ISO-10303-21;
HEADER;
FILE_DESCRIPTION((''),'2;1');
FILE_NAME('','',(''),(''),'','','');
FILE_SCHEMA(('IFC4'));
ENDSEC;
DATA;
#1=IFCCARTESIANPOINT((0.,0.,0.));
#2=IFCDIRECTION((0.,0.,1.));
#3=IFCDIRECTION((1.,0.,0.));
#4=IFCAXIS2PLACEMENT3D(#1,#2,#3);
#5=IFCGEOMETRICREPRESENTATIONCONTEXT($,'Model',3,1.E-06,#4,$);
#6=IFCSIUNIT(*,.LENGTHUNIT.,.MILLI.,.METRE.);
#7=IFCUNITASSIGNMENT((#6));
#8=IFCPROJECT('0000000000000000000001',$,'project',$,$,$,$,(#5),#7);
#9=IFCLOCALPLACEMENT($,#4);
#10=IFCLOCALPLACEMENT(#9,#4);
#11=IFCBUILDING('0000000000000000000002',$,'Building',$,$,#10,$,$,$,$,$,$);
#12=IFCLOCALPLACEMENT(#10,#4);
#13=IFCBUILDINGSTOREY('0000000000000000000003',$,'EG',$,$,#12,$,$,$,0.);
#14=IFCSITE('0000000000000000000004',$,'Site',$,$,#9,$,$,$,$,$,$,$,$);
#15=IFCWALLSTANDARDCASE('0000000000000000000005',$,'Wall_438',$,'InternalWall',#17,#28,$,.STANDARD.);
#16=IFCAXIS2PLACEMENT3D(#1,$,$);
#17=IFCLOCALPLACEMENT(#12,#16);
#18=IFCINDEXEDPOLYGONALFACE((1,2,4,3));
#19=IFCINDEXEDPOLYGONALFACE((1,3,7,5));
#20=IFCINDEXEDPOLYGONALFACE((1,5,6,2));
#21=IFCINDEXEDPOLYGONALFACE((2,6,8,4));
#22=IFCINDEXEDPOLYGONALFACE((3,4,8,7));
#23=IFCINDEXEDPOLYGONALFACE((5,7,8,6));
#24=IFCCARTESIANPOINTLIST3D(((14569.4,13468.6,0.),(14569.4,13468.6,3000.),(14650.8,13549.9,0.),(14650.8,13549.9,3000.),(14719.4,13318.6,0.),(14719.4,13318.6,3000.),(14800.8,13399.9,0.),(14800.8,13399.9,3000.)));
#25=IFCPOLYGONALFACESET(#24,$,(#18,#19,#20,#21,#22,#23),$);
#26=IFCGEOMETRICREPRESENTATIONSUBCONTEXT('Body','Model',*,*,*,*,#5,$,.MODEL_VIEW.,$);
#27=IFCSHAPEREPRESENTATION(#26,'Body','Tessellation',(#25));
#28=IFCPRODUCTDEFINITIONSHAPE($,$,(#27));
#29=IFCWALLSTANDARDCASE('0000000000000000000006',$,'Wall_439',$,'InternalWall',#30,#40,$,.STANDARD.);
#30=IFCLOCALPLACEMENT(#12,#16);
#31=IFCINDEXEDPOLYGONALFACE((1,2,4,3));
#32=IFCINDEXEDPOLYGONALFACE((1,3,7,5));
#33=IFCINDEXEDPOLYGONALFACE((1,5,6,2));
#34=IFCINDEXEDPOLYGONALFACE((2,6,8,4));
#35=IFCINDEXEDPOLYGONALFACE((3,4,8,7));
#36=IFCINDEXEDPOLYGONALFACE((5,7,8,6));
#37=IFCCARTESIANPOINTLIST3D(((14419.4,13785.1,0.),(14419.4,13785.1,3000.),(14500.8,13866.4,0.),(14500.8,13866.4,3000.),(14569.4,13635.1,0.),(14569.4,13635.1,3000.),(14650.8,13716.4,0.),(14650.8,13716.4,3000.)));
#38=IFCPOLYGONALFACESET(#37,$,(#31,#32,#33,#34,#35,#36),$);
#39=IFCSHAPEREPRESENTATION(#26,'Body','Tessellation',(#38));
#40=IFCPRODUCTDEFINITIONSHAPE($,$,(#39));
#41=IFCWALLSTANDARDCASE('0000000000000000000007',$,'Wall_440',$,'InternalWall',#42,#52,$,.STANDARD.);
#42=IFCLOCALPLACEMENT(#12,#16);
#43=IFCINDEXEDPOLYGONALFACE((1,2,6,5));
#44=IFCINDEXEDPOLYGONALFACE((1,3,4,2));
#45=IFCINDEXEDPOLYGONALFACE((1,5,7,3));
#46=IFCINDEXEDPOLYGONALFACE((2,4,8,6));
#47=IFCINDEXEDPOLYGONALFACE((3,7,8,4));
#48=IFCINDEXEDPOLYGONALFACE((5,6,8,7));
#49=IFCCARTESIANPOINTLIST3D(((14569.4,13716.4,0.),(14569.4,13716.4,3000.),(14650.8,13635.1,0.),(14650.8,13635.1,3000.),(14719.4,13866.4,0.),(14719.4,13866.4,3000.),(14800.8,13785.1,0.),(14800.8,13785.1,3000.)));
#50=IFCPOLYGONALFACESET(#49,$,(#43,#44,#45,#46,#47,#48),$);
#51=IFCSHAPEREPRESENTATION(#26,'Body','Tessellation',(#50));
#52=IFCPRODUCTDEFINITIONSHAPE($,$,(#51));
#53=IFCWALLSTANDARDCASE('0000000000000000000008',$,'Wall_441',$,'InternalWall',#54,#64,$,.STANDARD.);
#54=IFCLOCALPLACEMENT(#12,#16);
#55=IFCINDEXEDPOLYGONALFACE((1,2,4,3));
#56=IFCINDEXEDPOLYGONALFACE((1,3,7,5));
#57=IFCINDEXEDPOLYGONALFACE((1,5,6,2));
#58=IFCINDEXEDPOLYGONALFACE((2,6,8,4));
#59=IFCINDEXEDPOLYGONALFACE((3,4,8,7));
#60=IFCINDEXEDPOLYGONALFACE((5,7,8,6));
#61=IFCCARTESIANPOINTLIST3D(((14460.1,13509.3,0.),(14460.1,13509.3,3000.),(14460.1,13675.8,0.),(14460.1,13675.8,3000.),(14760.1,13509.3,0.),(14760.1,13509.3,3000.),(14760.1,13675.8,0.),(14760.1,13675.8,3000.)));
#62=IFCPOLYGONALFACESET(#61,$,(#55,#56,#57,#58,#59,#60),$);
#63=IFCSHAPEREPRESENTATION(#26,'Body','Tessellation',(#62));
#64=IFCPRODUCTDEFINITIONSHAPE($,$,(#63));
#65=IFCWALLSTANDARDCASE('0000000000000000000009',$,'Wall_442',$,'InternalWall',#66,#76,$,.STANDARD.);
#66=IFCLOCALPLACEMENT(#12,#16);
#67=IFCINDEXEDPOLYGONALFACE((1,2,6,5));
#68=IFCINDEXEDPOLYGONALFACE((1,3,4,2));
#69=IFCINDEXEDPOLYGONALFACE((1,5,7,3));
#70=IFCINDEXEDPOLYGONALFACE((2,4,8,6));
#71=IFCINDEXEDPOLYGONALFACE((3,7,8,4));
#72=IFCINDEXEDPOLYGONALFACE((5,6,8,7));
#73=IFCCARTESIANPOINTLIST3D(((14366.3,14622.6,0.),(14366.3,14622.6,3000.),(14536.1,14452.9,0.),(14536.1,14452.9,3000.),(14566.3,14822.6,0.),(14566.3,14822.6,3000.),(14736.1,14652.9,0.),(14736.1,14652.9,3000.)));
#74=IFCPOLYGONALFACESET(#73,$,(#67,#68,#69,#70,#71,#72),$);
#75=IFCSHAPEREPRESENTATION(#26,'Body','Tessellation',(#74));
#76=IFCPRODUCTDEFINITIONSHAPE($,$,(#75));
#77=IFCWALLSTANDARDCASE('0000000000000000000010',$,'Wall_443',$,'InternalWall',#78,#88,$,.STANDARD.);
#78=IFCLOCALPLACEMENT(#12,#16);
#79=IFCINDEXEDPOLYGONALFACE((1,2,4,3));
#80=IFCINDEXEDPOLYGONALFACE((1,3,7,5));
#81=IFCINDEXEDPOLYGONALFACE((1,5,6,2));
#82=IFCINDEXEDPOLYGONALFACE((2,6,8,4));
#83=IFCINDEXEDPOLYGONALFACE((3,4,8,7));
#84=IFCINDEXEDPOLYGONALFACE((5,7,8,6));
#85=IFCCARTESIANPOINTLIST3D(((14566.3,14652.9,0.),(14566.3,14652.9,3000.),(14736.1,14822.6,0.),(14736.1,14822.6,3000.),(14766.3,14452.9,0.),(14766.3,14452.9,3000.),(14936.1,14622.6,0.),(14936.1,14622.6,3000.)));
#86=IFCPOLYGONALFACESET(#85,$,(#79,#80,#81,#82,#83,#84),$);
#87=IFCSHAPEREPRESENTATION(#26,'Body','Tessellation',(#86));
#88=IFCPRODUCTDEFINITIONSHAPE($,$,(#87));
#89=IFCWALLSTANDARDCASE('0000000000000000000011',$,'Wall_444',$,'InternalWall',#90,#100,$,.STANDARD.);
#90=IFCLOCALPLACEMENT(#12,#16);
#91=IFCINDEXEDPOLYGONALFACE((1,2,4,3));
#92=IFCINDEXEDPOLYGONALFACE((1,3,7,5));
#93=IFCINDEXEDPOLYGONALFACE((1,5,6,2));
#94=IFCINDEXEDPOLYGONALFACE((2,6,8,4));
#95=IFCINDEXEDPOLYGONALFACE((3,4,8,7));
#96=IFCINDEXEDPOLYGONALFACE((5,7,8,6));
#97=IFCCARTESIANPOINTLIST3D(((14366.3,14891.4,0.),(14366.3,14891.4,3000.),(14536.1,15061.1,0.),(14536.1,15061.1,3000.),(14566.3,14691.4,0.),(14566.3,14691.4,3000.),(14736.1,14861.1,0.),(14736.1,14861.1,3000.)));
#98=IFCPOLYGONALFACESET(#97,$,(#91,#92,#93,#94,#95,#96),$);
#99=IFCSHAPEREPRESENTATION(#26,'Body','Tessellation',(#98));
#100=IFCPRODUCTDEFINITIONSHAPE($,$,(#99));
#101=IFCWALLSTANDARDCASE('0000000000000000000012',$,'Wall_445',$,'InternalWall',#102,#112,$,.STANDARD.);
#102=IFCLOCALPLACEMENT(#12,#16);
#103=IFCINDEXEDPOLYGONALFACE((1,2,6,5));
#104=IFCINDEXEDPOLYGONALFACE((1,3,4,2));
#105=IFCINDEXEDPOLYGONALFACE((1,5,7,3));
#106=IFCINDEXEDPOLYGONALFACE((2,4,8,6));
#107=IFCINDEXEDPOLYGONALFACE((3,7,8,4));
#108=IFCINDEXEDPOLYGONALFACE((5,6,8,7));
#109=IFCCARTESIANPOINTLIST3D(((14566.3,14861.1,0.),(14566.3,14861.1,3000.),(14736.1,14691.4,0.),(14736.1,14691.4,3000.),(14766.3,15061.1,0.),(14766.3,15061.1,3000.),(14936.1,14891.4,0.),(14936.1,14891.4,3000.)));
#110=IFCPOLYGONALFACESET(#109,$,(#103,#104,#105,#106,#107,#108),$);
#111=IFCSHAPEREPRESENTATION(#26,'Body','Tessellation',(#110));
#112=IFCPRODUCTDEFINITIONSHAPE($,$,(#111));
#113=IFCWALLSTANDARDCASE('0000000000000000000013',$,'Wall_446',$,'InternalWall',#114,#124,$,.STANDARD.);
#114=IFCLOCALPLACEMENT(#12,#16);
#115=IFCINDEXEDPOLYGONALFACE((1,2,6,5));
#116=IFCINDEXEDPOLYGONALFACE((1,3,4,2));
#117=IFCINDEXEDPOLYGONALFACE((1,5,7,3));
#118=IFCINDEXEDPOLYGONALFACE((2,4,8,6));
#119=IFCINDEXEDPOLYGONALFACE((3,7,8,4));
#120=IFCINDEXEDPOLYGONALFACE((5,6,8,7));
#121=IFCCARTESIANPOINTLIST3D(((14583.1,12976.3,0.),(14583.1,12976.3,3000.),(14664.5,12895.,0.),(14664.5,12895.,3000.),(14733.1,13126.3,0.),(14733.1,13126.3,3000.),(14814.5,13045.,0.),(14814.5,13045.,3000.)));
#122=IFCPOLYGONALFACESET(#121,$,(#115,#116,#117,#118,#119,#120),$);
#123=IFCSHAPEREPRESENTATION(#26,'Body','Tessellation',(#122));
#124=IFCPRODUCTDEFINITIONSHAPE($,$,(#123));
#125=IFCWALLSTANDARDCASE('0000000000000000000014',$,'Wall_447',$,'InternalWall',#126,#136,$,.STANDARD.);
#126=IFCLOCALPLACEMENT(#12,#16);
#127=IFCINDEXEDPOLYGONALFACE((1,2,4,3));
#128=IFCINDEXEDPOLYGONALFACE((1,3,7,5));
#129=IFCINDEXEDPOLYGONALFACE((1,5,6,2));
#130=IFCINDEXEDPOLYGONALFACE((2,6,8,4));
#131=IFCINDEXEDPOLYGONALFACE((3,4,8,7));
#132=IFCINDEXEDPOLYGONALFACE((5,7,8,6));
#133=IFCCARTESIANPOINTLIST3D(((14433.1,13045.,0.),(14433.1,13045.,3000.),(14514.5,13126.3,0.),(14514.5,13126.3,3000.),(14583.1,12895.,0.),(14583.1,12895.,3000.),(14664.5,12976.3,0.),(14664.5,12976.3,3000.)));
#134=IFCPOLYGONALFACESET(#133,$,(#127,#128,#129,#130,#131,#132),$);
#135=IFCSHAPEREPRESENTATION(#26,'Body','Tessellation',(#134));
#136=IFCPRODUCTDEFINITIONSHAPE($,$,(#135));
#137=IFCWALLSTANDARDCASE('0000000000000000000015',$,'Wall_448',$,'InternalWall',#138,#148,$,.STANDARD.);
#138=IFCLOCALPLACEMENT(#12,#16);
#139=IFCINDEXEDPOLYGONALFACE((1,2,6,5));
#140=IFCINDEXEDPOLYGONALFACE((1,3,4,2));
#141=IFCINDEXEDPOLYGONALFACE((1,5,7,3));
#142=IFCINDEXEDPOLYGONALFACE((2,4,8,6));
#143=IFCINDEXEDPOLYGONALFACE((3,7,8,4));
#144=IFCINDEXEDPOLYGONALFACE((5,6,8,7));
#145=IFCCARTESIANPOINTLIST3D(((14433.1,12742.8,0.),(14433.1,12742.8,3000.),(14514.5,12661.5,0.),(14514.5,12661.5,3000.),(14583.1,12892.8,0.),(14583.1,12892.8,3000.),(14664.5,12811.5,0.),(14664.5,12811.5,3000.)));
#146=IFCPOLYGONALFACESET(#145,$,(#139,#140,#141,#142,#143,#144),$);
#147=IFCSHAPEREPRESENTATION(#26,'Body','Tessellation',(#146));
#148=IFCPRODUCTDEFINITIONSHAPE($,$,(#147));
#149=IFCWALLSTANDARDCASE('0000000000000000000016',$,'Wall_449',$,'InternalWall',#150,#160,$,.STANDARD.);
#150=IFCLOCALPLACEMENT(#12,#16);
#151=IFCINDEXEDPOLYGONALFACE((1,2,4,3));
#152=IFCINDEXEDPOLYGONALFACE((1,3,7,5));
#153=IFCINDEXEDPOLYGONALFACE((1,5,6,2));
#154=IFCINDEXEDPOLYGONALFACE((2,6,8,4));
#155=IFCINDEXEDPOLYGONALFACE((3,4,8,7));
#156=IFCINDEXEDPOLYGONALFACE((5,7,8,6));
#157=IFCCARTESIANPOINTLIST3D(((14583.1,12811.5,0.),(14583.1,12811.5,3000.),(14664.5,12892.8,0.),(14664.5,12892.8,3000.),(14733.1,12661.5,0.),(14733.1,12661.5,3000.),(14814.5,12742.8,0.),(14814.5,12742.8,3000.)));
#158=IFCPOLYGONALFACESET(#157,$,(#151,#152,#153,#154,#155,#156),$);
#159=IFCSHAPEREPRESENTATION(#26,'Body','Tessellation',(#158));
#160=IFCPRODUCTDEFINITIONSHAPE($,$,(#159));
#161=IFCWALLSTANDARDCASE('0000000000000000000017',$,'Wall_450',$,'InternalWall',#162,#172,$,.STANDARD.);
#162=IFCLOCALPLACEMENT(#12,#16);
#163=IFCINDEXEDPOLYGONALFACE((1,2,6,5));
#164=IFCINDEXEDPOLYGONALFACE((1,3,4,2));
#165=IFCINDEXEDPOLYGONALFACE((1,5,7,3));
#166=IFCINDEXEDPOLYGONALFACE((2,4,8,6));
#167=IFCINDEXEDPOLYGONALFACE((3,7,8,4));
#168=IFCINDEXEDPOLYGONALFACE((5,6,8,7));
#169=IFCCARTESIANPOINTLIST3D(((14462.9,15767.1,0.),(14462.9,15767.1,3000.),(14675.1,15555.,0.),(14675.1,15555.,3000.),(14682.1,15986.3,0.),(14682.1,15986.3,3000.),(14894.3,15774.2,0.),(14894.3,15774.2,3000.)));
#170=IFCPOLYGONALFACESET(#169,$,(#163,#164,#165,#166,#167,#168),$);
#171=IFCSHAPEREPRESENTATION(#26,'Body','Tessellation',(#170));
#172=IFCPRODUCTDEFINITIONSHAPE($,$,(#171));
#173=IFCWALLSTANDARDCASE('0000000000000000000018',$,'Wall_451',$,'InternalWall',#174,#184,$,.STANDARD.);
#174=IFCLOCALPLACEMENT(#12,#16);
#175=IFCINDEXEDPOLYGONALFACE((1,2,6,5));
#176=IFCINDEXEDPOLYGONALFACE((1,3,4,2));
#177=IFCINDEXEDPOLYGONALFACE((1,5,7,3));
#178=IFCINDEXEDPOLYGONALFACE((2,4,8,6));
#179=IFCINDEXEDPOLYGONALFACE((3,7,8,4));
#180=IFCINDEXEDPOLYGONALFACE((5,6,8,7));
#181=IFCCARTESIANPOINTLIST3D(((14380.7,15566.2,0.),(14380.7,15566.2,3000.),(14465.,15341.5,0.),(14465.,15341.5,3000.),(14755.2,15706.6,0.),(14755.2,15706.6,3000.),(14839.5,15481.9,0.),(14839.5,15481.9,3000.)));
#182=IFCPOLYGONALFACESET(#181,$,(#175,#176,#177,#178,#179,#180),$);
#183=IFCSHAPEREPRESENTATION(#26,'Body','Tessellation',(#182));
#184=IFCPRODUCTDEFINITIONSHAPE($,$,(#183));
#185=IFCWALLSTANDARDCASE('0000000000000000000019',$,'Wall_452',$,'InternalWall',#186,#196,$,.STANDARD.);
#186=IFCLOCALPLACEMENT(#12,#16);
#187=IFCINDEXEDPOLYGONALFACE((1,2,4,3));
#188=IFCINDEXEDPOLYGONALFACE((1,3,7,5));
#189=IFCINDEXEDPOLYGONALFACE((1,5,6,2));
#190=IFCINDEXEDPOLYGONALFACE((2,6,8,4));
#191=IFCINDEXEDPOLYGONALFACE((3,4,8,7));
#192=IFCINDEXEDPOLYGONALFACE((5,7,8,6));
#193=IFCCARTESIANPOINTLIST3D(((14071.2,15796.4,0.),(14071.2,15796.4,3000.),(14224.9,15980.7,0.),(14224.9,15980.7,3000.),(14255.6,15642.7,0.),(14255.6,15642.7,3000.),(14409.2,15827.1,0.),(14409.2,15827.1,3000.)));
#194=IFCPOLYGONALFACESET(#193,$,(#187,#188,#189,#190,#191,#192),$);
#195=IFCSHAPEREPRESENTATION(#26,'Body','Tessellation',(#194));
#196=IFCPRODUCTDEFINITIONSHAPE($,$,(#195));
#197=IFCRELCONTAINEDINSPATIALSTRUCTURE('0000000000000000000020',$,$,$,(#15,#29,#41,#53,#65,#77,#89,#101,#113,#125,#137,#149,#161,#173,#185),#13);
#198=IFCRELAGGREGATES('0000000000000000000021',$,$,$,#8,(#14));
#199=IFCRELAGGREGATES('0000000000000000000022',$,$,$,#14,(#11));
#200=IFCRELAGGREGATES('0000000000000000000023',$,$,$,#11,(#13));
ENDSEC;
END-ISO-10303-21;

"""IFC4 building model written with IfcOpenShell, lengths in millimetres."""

from ifc_helpers import new_model, si_unit, frame, origin_with_axes, place, context, subcontext, project, spatial, rectangle, extrude, element, save


model = new_model("IFC4")

# Units and contexts
model_context = context("Model", 3, precision=1e-06, world=origin_with_axes())
body_context = subcontext(model_context, "Body", "Model", "MODEL_VIEW")
ifc_project = project(units=[si_unit("LENGTHUNIT", "METRE", prefix="MILLI")], contexts=[model_context])

# Site, building, storey
site_placement = place(None, origin_with_axes())
site = spatial("IfcSite", under=ifc_project, at=site_placement, Name="Site")
building_placement = place(site_placement, origin_with_axes())
building = spatial("IfcBuilding", under=site, at=building_placement, Name="Building")
storey_placement = place(building_placement, origin_with_axes())
storey = spatial("IfcBuildingStorey", under=building, at=storey_placement, Name="EG", Elevation=0.0)

# Walls
wall_1_placement = place(storey_placement, origin_with_axes())
element("IfcWallStandardCase", 1, at=wall_1_placement, inside=storey, Name="Wall_438", ObjectType="InternalWall", PredefinedType="STANDARD", context=body_context, shape_type="SweptSolid", body=[
    extrude(rectangle(XDim=212.1, YDim=115.0), frame((14685.1, 13434.3, 0.0), z_axis=(0.0, 0.0, 1.0), x_axis=(0.707107, -0.707107, 0.0)), (0.0, 0.0, 1.0), 3000.0),
])
wall_2_placement = place(storey_placement, origin_with_axes())
element("IfcWallStandardCase", 2, at=wall_2_placement, inside=storey, Name="Wall_439", ObjectType="InternalWall", PredefinedType="STANDARD", context=body_context, shape_type="SweptSolid", body=[
    extrude(rectangle(XDim=212.1, YDim=115.0), frame((14535.1, 13750.8, 0.0), z_axis=(0.0, 0.0, 1.0), x_axis=(-0.707107, 0.707107, 0.0)), (0.0, 0.0, 1.0), 3000.0),
])
wall_3_placement = place(storey_placement, origin_with_axes())
element("IfcWallStandardCase", 3, at=wall_3_placement, inside=storey, Name="Wall_440", ObjectType="InternalWall", PredefinedType="STANDARD", context=body_context, shape_type="SweptSolid", body=[
    extrude(rectangle(XDim=212.1, YDim=115.0), frame((14685.1, 13750.8, 0.0), z_axis=(0.0, 0.0, 1.0), x_axis=(0.707107, 0.707107, 0.0)), (0.0, 0.0, 1.0), 3000.0),
])
wall_4_placement = place(storey_placement, origin_with_axes())
element("IfcWallStandardCase", 4, at=wall_4_placement, inside=storey, Name="Wall_441", ObjectType="InternalWall", PredefinedType="STANDARD", context=body_context, shape_type="SweptSolid", body=[
    extrude(rectangle(XDim=166.5, YDim=300.0), frame((14610.1, 13592.5, 0.0), z_axis=(0.0, 0.0, 1.0), x_axis=(0.0, 1.0, 0.0)), (0.0, 0.0, 1.0), 3000.0),
])
wall_5_placement = place(storey_placement, origin_with_axes())
element("IfcWallStandardCase", 5, at=wall_5_placement, inside=storey, Name="Wall_442", ObjectType="InternalWall", PredefinedType="STANDARD", context=body_context, shape_type="SweptSolid", body=[
    extrude(rectangle(XDim=282.8, YDim=240.0), frame((14551.2, 14637.8, 0.0), z_axis=(0.0, 0.0, 1.0), x_axis=(-0.707107, -0.707107, 0.0)), (0.0, 0.0, 1.0), 3000.0),
])
wall_6_placement = place(storey_placement, origin_with_axes())
element("IfcWallStandardCase", 6, at=wall_6_placement, inside=storey, Name="Wall_443", ObjectType="InternalWall", PredefinedType="STANDARD", context=body_context, shape_type="SweptSolid", body=[
    extrude(rectangle(XDim=282.8, YDim=240.0), frame((14751.2, 14637.8, 0.0), z_axis=(0.0, 0.0, 1.0), x_axis=(0.707107, -0.707107, 0.0)), (0.0, 0.0, 1.0), 3000.0),
])
wall_7_placement = place(storey_placement, origin_with_axes())
element("IfcWallStandardCase", 7, at=wall_7_placement, inside=storey, Name="Wall_444", ObjectType="InternalWall", PredefinedType="STANDARD", context=body_context, shape_type="SweptSolid", body=[
    extrude(rectangle(XDim=282.8, YDim=240.0), frame((14551.2, 14876.3, 0.0), z_axis=(0.0, 0.0, 1.0), x_axis=(-0.707107, 0.707107, 0.0)), (0.0, 0.0, 1.0), 3000.0),
])
wall_8_placement = place(storey_placement, origin_with_axes())
element("IfcWallStandardCase", 8, at=wall_8_placement, inside=storey, Name="Wall_445", ObjectType="InternalWall", PredefinedType="STANDARD", context=body_context, shape_type="SweptSolid", body=[
    extrude(rectangle(XDim=282.8, YDim=240.0), frame((14751.2, 14876.3, 0.0), z_axis=(0.0, 0.0, 1.0), x_axis=(0.707107, 0.707107, 0.0)), (0.0, 0.0, 1.0), 3000.0),
])
wall_9_placement = place(storey_placement, origin_with_axes())
element("IfcWallStandardCase", 9, at=wall_9_placement, inside=storey, Name="Wall_446", ObjectType="InternalWall", PredefinedType="STANDARD", context=body_context, shape_type="SweptSolid", body=[
    extrude(rectangle(XDim=212.1, YDim=115.0), frame((14698.8, 13010.6, 0.0), z_axis=(0.0, 0.0, 1.0), x_axis=(-0.707107, -0.707107, 0.0)), (0.0, 0.0, 1.0), 3000.0),
])
wall_10_placement = place(storey_placement, origin_with_axes())
element("IfcWallStandardCase", 10, at=wall_10_placement, inside=storey, Name="Wall_447", ObjectType="InternalWall", PredefinedType="STANDARD", context=body_context, shape_type="SweptSolid", body=[
    extrude(rectangle(XDim=212.1, YDim=115.0), frame((14548.8, 13010.6, 0.0), z_axis=(0.0, 0.0, 1.0), x_axis=(-0.707107, 0.707107, 0.0)), (0.0, 0.0, 1.0), 3000.0),
])
wall_11_placement = place(storey_placement, origin_with_axes())
element("IfcWallStandardCase", 11, at=wall_11_placement, inside=storey, Name="Wall_448", ObjectType="InternalWall", PredefinedType="STANDARD", context=body_context, shape_type="SweptSolid", body=[
    extrude(rectangle(XDim=212.1, YDim=115.0), frame((14548.8, 12777.1, 0.0), z_axis=(0.0, 0.0, 1.0), x_axis=(-0.707107, -0.707107, 0.0)), (0.0, 0.0, 1.0), 3000.0),
])
wall_12_placement = place(storey_placement, origin_with_axes())
element("IfcWallStandardCase", 12, at=wall_12_placement, inside=storey, Name="Wall_449", ObjectType="InternalWall", PredefinedType="STANDARD", context=body_context, shape_type="SweptSolid", body=[
    extrude(rectangle(XDim=212.1, YDim=115.0), frame((14698.8, 12777.1, 0.0), z_axis=(0.0, 0.0, 1.0), x_axis=(0.707107, -0.707107, 0.0)), (0.0, 0.0, 1.0), 3000.0),
])
wall_13_placement = place(storey_placement, origin_with_axes())
element("IfcWallStandardCase", 13, at=wall_13_placement, inside=storey, Name="Wall_450", ObjectType="InternalWall", PredefinedType="STANDARD", context=body_context, shape_type="SweptSolid", body=[
    extrude(rectangle(XDim=310.0, YDim=300.0), frame((14678.6, 15770.6, 0.0), z_axis=(0.0, 0.0, 1.0), x_axis=(-0.707107, -0.707107, 0.0)), (0.0, 0.0, 1.0), 3000.0),
])
wall_14_placement = place(storey_placement, origin_with_axes())
element("IfcWallStandardCase", 14, at=wall_14_placement, inside=storey, Name="Wall_451", ObjectType="InternalWall", PredefinedType="STANDARD", context=body_context, shape_type="SweptSolid", body=[
    extrude(rectangle(XDim=400.0, YDim=240.0), frame((14610.1, 15524.1, 0.0), z_axis=(0.0, 0.0, 1.0), x_axis=(-0.936329, -0.351123, 0.0)), (0.0, 0.0, 1.0), 3000.0),
])
wall_15_placement = place(storey_placement, origin_with_axes())
element("IfcWallStandardCase", 15, at=wall_15_placement, inside=storey, Name="Wall_452", ObjectType="InternalWall", PredefinedType="STANDARD", context=body_context, shape_type="SweptSolid", body=[
    extrude(rectangle(XDim=240.0, YDim=240.0), frame((14240.2, 15811.7, 0.0), z_axis=(0.0, 0.0, 1.0), x_axis=(0.640184, 0.768221, 0.0)), (0.0, 0.0, 1.0), 3000.0),
])

save(model, "model.ifc")
